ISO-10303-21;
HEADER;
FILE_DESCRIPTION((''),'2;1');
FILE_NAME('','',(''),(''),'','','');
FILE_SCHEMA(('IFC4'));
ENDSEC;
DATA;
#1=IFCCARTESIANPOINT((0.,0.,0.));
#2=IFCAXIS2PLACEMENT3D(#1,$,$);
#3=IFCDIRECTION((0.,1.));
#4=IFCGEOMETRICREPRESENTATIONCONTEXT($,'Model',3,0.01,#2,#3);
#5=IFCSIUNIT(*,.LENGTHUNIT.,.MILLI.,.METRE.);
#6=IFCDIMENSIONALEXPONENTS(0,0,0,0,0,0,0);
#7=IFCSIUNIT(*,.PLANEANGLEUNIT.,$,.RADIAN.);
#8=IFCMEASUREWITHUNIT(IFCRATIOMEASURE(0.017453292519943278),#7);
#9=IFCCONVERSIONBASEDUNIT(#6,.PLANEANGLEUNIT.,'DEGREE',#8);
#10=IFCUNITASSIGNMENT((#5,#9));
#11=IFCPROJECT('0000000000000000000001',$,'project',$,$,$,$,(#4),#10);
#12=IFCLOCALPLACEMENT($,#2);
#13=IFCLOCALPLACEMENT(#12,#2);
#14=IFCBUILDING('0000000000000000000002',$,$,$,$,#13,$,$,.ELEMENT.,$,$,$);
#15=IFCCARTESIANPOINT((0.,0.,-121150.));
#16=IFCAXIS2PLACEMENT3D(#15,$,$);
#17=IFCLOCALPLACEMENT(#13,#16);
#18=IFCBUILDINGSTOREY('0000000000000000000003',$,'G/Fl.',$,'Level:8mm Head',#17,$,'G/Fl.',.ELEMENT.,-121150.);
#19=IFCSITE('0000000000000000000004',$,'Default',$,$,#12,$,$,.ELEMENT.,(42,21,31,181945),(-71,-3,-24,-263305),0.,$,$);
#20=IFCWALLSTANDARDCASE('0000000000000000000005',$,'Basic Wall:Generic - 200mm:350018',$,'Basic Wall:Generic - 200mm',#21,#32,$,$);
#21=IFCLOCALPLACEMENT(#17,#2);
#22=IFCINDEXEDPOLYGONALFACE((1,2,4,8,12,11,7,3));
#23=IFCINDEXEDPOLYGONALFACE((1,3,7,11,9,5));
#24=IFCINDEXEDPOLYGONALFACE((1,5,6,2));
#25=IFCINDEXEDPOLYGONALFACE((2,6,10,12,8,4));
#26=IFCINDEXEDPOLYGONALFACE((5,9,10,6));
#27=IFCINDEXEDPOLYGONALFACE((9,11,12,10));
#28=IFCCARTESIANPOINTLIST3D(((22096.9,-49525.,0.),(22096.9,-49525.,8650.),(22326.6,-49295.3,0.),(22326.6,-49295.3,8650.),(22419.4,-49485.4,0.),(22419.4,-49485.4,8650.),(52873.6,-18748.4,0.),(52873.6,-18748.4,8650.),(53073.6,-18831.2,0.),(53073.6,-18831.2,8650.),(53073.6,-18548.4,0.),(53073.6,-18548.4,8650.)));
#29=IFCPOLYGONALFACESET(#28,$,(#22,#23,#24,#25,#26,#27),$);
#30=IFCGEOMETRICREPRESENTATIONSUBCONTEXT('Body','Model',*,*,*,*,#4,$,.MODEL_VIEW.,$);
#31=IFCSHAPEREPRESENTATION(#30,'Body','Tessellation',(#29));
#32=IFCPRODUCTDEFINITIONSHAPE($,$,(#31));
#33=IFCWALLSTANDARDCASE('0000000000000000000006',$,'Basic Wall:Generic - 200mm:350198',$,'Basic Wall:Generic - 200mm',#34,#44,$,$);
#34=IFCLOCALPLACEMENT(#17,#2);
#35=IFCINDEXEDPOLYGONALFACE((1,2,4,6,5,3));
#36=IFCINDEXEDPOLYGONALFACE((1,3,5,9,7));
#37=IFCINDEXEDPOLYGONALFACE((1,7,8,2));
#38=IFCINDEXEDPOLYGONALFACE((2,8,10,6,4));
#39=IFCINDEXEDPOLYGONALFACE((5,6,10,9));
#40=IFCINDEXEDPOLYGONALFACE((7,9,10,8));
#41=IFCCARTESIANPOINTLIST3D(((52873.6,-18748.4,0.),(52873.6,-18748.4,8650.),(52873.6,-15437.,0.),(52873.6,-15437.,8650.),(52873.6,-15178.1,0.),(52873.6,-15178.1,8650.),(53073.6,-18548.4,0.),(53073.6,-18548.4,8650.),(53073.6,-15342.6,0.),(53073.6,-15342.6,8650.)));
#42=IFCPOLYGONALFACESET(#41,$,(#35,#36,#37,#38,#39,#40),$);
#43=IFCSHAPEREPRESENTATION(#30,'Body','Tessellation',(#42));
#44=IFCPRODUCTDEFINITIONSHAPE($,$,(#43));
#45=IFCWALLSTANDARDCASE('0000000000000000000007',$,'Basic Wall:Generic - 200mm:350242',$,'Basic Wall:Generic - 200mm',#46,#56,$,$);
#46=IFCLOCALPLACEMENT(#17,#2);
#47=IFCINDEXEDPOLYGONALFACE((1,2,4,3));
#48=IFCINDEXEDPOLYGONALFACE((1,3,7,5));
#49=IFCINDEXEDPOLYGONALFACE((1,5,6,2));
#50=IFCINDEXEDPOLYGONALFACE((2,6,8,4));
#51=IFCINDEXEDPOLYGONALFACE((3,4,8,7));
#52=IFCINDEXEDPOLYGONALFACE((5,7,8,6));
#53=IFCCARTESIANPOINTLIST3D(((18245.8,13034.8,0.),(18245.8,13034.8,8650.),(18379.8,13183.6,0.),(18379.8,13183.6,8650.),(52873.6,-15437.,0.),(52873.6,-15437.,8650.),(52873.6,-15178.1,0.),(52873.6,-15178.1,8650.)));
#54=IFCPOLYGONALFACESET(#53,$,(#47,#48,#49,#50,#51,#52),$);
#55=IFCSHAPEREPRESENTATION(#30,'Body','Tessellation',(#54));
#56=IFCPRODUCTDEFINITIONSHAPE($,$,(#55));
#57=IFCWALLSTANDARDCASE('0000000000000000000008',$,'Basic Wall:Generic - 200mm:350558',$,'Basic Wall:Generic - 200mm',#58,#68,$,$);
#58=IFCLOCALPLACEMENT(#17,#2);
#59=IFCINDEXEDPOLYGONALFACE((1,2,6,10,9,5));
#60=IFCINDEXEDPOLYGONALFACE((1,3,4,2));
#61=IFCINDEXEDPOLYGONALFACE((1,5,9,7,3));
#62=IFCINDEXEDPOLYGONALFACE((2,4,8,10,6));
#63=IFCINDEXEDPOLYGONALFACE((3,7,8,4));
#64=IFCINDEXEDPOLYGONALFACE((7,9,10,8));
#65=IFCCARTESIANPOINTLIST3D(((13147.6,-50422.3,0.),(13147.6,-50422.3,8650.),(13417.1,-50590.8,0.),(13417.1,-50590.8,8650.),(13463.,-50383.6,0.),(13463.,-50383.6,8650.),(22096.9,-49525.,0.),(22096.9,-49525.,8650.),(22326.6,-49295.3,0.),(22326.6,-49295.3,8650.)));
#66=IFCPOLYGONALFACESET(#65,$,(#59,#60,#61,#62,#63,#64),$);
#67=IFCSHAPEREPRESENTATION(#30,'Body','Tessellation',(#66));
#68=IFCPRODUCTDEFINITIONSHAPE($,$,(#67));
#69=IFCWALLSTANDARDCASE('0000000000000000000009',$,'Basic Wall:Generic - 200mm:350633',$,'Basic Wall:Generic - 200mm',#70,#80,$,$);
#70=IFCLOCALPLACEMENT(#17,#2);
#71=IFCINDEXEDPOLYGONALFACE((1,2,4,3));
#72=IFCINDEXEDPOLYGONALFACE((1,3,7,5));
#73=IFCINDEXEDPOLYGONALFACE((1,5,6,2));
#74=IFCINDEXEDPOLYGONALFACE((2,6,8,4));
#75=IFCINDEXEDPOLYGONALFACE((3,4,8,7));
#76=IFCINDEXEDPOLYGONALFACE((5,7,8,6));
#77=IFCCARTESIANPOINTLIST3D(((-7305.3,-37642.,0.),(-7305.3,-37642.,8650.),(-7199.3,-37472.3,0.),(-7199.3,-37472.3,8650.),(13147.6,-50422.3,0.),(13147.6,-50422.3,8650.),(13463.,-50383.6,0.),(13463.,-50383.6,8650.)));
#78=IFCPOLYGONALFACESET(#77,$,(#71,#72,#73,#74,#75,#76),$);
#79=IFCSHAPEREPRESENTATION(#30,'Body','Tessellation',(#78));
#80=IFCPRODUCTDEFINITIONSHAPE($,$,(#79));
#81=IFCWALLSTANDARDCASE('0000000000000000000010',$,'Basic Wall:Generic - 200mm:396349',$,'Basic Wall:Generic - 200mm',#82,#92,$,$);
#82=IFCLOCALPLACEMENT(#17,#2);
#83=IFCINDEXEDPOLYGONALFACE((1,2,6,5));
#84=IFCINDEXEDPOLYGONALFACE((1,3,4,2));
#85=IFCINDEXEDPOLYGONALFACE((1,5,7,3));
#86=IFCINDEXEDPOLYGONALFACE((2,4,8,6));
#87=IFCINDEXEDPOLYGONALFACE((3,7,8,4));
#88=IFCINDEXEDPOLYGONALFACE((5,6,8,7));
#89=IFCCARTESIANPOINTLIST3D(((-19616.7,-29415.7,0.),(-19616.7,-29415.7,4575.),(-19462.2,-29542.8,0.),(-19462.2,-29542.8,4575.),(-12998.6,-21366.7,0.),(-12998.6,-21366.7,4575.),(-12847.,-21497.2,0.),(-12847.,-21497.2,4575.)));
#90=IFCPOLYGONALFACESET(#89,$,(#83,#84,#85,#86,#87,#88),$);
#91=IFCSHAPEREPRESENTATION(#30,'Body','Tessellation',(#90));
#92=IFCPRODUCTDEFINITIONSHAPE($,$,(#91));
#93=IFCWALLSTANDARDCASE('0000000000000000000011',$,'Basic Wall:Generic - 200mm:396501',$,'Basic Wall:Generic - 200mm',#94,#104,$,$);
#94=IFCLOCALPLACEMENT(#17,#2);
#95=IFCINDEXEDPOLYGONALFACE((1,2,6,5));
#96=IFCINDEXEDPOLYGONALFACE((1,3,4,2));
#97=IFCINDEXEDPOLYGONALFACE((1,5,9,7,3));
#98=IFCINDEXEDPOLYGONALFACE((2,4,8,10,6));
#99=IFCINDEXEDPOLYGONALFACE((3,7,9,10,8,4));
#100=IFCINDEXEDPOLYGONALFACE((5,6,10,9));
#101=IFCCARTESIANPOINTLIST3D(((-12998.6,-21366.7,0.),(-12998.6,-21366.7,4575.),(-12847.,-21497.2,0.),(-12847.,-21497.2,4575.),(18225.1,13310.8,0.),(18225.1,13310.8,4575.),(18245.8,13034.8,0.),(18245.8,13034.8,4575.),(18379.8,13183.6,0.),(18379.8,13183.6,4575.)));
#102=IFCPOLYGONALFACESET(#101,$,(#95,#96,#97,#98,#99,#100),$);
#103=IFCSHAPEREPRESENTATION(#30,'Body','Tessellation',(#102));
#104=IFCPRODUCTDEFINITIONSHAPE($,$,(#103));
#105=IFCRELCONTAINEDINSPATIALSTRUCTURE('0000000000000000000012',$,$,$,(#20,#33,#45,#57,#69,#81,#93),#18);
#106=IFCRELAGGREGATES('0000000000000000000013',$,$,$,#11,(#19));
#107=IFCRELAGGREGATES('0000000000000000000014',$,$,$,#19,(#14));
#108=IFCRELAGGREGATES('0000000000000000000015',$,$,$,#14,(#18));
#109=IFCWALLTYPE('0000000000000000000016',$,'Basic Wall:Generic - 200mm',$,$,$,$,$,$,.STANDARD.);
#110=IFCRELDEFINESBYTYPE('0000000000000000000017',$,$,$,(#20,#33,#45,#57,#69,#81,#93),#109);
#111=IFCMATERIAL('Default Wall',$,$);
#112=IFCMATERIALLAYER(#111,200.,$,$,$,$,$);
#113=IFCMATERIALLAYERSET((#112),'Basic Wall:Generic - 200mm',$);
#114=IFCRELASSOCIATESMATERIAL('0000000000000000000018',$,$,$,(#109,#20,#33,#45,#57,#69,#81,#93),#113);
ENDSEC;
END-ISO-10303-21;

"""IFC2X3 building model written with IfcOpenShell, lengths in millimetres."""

from ifc_helpers import new_model, entity, si_unit, converted_unit, direction, frame, origin, place, context, subcontext, project, spatial, polyline, outline, extrude, material, layer, layer_set, layer_usage, type_object, element, save


model = new_model("IFC2X3")

# Units and contexts
model_context = context("Model", 3, precision=0.01, world=origin(), true_north=direction((0.0, 1.0)))
body_context = subcontext(model_context, "Body", "Model", "MODEL_VIEW")
ifc_project = project(units=[si_unit("LENGTHUNIT", "METRE", prefix="MILLI"), converted_unit("PLANEANGLEUNIT", "DEGREE", entity("IfcRatioMeasure", 0.017453292519943278), si_unit("PLANEANGLEUNIT", "RADIAN"), dimensions=[0, 0, 0, 0, 0, 0, 0])], contexts=[model_context])

# Site, building, storey
site_placement = place(None, origin())
site = spatial("IfcSite", under=ifc_project, at=site_placement, Name="Default", CompositionType="ELEMENT", RefLatitude=(42, 21, 31, 181945), RefLongitude=(-71, -3, -24, -263305), RefElevation=0.0)
building_placement = place(site_placement, origin())
building = spatial("IfcBuilding", under=site, at=building_placement, CompositionType="ELEMENT")
storey_placement = place(building_placement, frame((0.0, 0.0, -121150.0)))
storey = spatial("IfcBuildingStorey", under=building, at=storey_placement, Name="G/Fl.", ObjectType="Level:8mm Head", LongName="G/Fl.", CompositionType="ELEMENT", Elevation=-121150.0)

# Walls
ifc_material_1 = material(Name="Default Wall")
ifc_layer_1 = layer(ifc_material_1, 200.0)
ifc_layer_set_1 = layer_set([ifc_layer_1], Name="Basic Wall:Generic - 200mm")
ifc_layer_usage_1 = layer_usage(ifc_layer_set_1, "AXIS2", "NEGATIVE", 100.0)
wall_type = type_object("IfcWallType", Name="Basic Wall:Generic - 200mm", PredefinedType="STANDARD", material=ifc_layer_set_1)
wall_1_placement = place(storey_placement, frame((22167.6, -49595.7, 0.0), z_axis=(0.0, 0.0, 1.0), x_axis=(0.707107, 0.707107, 0.0)))
element("IfcWallStandardCase", 1, at=wall_1_placement, inside=storey, type_object=wall_type, material=ifc_layer_usage_1, Name="Basic Wall:Generic - 200mm:350018", ObjectType="Basic Wall:Generic - 200mm", context=body_context, shape_type="SweptSolid", body=[
    extrude(outline(polyline([(43607.6, -100.0), (43807.6, 100.0), (43524.7, 100.0), (324.9, 100.0), (0.0, 100.0), (256.0, -100.0), (43607.6, -100.0)])), origin(), (0.0, 0.0, 1.0), 8650.0),
])
wall_2_placement = place(storey_placement, frame((52973.6, -18748.4, 0.0), z_axis=(0.0, 0.0, 1.0), x_axis=(0.0, 1.0, 0.0)))
element("IfcWallStandardCase", 2, at=wall_2_placement, inside=storey, type_object=wall_type, material=ifc_layer_usage_1, Name="Basic Wall:Generic - 200mm:350198", ObjectType="Basic Wall:Generic - 200mm", context=body_context, shape_type="SweptSolid", body=[
    extrude(outline(polyline([(3405.8, -100.0), (3570.3, 100.0), (3311.3, 100.0), (0.0, 100.0), (200.0, -100.0), (3405.8, -100.0)])), origin(), (0.0, 0.0, 1.0), 8650.0),
])
wall_3_placement = place(storey_placement, frame((52937.1, -15359.8, 0.0), z_axis=(0.0, 0.0, 1.0), x_axis=(-0.772424, 0.635107, 0.0)))
element("IfcWallStandardCase", 3, at=wall_3_placement, inside=storey, type_object=wall_type, material=ifc_layer_usage_1, Name="Basic Wall:Generic - 200mm:350242", ObjectType="Basic Wall:Generic - 200mm", context=body_context, shape_type="SweptSolid", body=[
    extrude(outline(polyline([(44821.0, -100.0), (44830.0, 100.0), (0.0, 100.0), (164.4, -100.0), (44821.0, -100.0)])), origin(), (0.0, 0.0, 1.0), 8650.0),
])
wall_4_placement = place(storey_placement, frame((22338.8, -49394.6, 0.0), z_axis=(0.0, 0.0, 1.0), x_axis=(-0.992546, -0.121869, 0.0)))
element("IfcWallStandardCase", 4, at=wall_4_placement, inside=storey, type_object=wall_type, material=ifc_layer_usage_1, Name="Basic Wall:Generic - 200mm:350558", ObjectType="Basic Wall:Generic - 200mm", context=body_context, shape_type="SweptSolid", body=[
    extrude(outline(polyline([(9248.0, -100.0), (9001.0, 100.0), (256.0, 100.0), (0.0, -100.0), (8930.2, -100.0), (9248.0, -100.0)])), origin(), (0.0, 0.0, 1.0), 8650.0),
])
wall_5_placement = place(storey_placement, frame((13410.1, -50468.4, 0.0), z_axis=(0.0, 0.0, 1.0), x_axis=(-0.848048, 0.529919, 0.0)))
element("IfcWallStandardCase", 5, at=wall_5_placement, inside=storey, type_object=wall_type, material=ifc_layer_usage_1, Name="Basic Wall:Generic - 200mm:350633", ObjectType="Basic Wall:Generic - 200mm", context=body_context, shape_type="SweptSolid", body=[
    extrude(outline(polyline([(24364.6, -100.0), (24364.6, 100.0), (247.0, 100.0), (0.0, -100.0), (24364.6, -100.0)])), origin(), (0.0, 0.0, 1.0), 8650.0),
])
wall_6_placement = place(storey_placement, frame((-19539.5, -29479.3, 0.0), z_axis=(0.0, 0.0, 1.0), x_axis=(0.635107, 0.772424, 0.0)))
element("IfcWallStandardCase", 6, at=wall_6_placement, inside=storey, type_object=wall_type, material=ifc_layer_usage_1, Name="Basic Wall:Generic - 200mm:396349", ObjectType="Basic Wall:Generic - 200mm", context=body_context, shape_type="SweptSolid", body=[
    extrude(outline(polyline([(10416.0, -100.0), (10420.5, 100.0), (0.0, 100.0), (0.0, -100.0), (10416.0, -100.0)])), origin(), (0.0, 0.0, 1.0), 4575.0),
])
wall_7_placement = place(storey_placement, frame((-12924.3, -21433.6, 0.0), z_axis=(0.0, 0.0, 1.0), x_axis=(0.669131, 0.743145, 0.0)))
element("IfcWallStandardCase", 7, at=wall_7_placement, inside=storey, type_object=wall_type, material=ifc_layer_usage_1, Name="Basic Wall:Generic - 200mm:396501", ObjectType="Basic Wall:Generic - 200mm", context=body_context, shape_type="SweptSolid", body=[
    extrude(outline(polyline([(46672.1, -100.0), (46663.1, 100.0), (0.0, 100.0), (4.5, -100.0), (46471.9, -100.0), (46672.1, -100.0)])), origin(), (0.0, 0.0, 1.0), 4575.0),
])

save(model, "model.ifc")
